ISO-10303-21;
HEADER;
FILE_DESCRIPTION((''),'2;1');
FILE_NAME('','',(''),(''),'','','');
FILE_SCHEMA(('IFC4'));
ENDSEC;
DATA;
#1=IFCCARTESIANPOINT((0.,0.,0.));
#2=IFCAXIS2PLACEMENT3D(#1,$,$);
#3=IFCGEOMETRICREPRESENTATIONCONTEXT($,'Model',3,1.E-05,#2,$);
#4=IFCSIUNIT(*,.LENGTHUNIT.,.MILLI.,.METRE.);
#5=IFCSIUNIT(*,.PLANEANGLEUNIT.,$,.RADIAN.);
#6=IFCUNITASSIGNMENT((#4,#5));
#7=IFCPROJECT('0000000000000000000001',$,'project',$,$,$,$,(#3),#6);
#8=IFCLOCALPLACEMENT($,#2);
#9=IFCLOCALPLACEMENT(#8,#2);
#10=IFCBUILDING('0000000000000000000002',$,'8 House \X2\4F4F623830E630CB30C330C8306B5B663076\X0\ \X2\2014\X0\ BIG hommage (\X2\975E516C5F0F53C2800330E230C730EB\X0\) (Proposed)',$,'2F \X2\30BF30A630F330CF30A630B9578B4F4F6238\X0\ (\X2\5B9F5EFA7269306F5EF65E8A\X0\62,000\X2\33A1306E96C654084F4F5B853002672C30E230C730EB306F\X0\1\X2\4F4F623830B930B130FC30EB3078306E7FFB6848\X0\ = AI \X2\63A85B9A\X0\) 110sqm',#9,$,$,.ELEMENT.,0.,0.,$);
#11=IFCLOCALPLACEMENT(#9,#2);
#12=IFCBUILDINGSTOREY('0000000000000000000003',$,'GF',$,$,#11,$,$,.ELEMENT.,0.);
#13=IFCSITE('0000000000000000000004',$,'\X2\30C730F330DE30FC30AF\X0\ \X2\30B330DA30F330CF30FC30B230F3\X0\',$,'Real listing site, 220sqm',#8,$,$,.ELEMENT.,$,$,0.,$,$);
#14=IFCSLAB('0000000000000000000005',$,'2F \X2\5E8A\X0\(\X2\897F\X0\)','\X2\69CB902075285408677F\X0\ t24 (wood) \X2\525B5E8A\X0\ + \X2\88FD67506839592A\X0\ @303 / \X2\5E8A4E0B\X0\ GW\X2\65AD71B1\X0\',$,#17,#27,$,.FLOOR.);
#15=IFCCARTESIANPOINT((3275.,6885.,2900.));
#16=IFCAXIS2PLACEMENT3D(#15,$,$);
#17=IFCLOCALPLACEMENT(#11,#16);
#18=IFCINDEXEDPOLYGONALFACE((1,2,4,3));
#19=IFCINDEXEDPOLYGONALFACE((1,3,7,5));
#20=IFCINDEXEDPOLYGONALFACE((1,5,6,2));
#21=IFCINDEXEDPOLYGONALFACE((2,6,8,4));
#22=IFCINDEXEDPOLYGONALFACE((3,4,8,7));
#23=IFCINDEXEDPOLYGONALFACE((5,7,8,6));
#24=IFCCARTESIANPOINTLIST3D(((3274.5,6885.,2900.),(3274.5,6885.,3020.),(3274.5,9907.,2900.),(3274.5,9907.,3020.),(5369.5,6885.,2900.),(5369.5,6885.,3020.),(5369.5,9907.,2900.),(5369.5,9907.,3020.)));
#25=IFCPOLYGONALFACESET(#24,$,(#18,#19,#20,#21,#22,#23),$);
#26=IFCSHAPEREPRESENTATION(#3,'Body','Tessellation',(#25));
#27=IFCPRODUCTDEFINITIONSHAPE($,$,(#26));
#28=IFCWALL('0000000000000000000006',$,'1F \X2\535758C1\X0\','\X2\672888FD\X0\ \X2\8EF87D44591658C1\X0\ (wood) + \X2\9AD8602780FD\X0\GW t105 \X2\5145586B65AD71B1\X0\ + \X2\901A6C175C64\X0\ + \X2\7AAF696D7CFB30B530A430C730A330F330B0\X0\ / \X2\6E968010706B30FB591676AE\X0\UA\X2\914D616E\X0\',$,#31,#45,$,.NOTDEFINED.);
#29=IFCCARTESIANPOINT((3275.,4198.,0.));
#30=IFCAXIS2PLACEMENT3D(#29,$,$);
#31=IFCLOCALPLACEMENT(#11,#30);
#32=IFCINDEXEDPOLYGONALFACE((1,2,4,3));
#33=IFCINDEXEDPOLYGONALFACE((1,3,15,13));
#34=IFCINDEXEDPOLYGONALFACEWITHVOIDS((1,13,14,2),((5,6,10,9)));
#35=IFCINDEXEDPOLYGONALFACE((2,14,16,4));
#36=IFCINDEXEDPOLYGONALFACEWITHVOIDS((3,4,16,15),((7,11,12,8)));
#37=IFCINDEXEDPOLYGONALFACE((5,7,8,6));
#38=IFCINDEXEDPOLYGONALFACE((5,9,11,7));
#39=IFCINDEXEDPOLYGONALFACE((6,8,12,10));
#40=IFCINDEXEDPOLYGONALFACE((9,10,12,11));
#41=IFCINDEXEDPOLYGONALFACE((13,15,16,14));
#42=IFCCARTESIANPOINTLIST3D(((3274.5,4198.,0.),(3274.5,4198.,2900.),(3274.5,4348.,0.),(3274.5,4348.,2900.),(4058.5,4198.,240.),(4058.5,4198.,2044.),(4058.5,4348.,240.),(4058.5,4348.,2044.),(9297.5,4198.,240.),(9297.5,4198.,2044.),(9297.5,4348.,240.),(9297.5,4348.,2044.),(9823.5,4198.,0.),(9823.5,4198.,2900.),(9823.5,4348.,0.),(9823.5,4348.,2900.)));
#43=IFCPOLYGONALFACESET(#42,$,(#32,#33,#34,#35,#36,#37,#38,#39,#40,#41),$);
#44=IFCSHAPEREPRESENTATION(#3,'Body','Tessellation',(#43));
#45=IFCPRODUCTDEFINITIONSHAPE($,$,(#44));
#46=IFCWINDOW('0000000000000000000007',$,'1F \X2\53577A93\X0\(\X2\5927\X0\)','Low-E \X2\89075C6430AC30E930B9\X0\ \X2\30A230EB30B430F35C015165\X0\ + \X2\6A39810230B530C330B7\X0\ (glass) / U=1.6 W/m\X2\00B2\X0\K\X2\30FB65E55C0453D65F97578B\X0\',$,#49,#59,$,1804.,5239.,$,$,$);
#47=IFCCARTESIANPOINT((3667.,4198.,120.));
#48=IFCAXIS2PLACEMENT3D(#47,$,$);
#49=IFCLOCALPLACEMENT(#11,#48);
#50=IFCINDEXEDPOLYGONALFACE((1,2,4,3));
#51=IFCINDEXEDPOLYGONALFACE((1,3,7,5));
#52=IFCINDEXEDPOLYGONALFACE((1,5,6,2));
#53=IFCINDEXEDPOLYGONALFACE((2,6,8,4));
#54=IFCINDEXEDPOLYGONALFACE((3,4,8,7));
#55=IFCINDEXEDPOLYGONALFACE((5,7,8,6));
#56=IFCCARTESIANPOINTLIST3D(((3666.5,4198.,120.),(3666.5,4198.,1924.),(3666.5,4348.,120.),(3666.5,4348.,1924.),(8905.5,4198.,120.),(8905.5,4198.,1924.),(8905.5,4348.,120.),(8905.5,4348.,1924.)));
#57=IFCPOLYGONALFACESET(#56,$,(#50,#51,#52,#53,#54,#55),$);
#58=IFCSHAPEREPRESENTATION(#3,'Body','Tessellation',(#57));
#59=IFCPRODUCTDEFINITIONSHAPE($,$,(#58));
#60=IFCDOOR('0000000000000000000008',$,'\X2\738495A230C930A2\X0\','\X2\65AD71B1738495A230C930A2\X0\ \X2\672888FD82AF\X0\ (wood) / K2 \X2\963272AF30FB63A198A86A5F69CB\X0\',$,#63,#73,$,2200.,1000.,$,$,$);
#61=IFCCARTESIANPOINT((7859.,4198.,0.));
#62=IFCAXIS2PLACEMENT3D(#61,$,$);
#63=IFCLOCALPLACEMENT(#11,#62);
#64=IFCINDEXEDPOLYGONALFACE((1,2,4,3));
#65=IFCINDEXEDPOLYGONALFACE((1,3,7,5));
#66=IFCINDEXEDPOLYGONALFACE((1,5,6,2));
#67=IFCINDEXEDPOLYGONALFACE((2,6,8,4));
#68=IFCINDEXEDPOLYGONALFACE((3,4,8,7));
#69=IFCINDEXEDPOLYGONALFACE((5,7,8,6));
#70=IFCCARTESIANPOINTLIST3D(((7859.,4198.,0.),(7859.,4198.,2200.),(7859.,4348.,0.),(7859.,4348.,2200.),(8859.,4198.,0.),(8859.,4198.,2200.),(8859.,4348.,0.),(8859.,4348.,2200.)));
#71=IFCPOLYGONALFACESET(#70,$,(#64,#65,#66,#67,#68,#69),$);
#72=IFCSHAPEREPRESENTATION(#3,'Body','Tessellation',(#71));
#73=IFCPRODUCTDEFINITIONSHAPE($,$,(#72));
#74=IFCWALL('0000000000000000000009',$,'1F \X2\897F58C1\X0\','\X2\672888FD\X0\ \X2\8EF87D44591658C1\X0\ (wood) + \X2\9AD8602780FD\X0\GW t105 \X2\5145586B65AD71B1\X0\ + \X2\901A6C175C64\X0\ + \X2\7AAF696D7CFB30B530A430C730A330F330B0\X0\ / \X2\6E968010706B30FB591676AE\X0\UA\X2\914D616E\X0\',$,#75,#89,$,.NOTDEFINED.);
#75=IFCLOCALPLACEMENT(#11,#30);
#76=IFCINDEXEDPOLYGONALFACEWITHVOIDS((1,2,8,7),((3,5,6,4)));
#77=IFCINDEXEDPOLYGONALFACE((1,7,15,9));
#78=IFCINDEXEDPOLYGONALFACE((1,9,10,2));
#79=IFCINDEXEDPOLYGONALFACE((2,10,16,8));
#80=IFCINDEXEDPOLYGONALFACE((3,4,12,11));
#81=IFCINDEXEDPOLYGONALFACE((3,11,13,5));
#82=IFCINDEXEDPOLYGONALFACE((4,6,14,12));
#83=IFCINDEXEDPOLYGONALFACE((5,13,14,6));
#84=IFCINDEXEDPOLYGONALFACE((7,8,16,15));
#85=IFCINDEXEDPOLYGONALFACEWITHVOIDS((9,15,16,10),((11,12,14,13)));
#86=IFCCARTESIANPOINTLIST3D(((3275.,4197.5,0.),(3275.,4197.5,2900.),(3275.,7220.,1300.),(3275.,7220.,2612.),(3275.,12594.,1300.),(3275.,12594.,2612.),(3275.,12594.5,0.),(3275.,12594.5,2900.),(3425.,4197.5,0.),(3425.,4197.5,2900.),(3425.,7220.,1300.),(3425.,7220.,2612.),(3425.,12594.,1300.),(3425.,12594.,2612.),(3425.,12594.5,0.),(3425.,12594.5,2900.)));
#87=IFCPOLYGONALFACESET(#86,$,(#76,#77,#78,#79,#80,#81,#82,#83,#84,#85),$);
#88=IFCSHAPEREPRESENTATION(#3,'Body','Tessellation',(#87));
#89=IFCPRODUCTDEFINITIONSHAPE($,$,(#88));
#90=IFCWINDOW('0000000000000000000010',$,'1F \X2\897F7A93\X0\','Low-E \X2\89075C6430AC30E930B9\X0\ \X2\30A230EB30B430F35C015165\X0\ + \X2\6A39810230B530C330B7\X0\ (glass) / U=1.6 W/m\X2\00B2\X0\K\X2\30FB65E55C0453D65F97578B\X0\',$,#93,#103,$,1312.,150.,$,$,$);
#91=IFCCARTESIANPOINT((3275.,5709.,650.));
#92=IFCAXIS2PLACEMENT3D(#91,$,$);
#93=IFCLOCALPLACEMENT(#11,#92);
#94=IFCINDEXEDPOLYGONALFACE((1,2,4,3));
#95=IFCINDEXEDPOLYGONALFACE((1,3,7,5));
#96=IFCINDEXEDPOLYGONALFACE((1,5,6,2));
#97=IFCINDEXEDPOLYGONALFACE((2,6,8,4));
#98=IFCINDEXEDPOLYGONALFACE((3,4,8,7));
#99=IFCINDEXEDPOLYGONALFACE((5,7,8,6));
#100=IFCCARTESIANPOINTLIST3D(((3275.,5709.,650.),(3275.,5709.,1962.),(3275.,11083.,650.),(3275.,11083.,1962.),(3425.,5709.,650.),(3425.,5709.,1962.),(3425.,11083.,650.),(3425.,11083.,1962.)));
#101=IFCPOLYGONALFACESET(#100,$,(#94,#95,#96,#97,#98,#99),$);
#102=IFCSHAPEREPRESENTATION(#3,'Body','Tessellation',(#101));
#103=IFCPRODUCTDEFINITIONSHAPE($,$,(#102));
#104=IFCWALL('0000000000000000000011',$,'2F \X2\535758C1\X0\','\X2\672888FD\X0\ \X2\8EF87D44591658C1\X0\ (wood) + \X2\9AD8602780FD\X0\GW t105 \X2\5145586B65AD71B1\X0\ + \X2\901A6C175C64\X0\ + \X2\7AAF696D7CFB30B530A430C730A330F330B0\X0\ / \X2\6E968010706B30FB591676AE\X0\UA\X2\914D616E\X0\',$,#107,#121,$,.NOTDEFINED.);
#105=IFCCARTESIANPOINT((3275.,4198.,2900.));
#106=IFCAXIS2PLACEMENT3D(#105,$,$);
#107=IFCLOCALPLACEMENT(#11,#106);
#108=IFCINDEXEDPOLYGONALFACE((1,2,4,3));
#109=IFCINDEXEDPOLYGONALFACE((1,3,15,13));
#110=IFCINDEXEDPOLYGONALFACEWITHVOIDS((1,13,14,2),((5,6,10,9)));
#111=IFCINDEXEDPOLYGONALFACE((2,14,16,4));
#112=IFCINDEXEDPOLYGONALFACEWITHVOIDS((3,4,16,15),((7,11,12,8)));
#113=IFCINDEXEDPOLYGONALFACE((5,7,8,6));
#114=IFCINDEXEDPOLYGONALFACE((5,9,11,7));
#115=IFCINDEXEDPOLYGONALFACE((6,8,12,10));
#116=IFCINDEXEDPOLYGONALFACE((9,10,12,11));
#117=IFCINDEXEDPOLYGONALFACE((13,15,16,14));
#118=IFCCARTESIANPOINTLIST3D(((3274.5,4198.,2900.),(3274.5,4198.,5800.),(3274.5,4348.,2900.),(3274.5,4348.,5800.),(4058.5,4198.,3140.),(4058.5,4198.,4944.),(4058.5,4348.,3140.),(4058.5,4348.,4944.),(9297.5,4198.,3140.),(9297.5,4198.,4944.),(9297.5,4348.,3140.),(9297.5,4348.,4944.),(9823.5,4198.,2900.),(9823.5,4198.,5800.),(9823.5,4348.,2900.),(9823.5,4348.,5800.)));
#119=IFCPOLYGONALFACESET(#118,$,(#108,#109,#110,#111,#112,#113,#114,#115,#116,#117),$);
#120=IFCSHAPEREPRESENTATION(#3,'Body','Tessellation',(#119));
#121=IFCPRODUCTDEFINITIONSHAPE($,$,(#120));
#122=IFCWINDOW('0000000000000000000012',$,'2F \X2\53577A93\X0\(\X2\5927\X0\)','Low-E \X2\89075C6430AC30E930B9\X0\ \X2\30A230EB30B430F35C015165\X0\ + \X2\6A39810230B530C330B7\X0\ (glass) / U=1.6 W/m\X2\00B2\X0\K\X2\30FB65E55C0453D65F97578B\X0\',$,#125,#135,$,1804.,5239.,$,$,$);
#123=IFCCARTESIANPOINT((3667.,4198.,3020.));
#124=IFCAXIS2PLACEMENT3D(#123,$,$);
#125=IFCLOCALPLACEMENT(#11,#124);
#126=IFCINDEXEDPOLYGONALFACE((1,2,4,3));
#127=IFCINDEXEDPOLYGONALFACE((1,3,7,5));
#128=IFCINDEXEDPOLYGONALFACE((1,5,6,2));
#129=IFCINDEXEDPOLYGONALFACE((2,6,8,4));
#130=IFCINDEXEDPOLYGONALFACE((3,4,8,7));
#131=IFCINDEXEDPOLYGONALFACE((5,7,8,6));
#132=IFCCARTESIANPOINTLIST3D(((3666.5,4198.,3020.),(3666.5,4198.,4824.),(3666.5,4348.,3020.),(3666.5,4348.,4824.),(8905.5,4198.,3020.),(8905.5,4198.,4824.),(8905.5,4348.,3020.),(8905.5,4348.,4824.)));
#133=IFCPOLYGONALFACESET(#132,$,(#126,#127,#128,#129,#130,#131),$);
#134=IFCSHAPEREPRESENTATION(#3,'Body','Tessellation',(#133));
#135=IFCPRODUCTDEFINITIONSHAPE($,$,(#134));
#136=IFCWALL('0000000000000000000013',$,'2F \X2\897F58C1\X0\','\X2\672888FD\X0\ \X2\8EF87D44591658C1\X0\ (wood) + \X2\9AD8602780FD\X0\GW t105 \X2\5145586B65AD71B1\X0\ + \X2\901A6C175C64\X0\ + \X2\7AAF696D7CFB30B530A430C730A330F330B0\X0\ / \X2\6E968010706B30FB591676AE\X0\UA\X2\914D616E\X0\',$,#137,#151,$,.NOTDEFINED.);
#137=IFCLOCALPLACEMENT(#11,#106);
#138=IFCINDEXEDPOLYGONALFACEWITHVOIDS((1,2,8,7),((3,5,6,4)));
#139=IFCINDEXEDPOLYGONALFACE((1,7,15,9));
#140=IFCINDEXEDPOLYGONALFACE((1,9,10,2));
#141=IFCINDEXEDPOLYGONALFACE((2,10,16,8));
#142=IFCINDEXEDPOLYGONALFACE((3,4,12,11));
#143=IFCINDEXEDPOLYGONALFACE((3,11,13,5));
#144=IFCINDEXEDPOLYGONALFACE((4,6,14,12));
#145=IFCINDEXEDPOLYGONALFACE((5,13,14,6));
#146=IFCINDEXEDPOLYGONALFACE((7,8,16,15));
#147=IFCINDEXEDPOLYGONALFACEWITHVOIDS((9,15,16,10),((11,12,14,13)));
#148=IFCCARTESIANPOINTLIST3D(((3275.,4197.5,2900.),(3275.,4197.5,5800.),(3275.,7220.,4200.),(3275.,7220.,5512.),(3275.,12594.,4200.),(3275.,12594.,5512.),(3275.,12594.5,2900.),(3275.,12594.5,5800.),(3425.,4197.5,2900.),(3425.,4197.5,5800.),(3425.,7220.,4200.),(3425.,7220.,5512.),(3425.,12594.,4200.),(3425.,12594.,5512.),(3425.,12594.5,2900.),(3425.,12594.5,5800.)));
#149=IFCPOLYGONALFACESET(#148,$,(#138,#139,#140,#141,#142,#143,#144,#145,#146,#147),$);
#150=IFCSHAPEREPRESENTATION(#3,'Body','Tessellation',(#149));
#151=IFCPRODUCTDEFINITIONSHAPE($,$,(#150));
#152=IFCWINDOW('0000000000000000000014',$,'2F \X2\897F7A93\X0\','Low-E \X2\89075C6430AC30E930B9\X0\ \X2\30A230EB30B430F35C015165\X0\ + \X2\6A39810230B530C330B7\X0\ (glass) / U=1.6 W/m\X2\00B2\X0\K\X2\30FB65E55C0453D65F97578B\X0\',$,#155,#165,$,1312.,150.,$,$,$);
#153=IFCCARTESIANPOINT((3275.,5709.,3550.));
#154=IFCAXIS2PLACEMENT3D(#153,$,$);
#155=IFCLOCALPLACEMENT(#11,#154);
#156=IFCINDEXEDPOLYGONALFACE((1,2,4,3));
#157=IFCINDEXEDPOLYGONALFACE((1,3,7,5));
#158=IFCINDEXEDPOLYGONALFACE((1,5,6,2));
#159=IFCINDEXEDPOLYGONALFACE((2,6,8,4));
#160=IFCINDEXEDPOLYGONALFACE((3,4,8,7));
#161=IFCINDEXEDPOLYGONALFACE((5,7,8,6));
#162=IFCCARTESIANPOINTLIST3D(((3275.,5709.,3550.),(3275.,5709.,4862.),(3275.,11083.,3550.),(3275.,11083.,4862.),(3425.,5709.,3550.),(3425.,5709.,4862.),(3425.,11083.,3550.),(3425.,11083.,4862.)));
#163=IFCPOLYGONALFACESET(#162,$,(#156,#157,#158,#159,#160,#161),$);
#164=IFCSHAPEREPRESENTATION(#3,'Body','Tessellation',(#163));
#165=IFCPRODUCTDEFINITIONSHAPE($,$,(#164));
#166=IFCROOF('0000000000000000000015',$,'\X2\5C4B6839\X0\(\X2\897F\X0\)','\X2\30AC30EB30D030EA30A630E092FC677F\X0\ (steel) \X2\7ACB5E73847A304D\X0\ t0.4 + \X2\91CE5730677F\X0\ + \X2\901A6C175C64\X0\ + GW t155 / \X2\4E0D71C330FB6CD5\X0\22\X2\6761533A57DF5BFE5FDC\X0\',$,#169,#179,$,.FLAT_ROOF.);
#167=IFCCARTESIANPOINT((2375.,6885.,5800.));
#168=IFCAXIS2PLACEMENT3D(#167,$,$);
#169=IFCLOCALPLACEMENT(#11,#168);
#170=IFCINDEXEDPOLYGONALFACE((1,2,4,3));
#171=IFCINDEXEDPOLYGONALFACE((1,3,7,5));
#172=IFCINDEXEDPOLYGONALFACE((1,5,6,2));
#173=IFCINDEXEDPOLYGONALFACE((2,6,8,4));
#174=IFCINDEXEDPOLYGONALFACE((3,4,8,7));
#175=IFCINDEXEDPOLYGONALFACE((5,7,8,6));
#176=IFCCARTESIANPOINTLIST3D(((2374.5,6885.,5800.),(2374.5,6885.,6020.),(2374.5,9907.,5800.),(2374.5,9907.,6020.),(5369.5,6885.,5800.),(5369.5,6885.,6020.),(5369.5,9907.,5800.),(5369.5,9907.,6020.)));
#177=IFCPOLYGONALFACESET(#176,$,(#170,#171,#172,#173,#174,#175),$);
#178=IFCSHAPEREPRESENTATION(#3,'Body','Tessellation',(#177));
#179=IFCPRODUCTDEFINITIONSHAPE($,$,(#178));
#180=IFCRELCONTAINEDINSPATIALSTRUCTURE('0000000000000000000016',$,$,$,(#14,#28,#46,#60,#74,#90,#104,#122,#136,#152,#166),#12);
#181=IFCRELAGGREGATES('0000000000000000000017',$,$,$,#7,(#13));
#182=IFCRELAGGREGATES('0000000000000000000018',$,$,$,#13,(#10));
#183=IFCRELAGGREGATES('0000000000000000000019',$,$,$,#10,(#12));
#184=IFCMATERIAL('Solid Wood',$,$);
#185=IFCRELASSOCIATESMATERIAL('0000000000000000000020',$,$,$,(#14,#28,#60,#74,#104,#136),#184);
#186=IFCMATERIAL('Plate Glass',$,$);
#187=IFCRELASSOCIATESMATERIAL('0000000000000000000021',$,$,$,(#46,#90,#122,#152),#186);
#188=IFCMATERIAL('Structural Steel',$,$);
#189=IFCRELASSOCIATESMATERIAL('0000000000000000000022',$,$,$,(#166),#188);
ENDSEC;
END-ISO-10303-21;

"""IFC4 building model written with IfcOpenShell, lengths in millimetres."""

from ifc_helpers import new_model, si_unit, frame, frame_2d, origin, place, context, project, spatial, rectangle, extrude, material, element, fill, save


model = new_model("IFC4")

# Units and contexts
model_context = context("Model", 3, precision=1e-05, world=origin())
ifc_project = project(units=[si_unit("LENGTHUNIT", "METRE", prefix="MILLI"), si_unit("PLANEANGLEUNIT", "RADIAN")], contexts=[model_context])

# Site, building, storey
site_placement = place(None, origin())
site = spatial("IfcSite", under=ifc_project, at=site_placement, Name="デンマーク コペンハーゲン", ObjectType="Real listing site, 220sqm", CompositionType="ELEMENT", RefElevation=0.0)
building_placement = place(site_placement, origin())
building = spatial("IfcBuilding", under=site, at=building_placement, Name="8 House 住戸ユニットに学ぶ — BIG hommage (非公式参考モデル) (Proposed)", ObjectType="2F タウンハウス型住戸 (実建物は延床62,000㎡の集合住宅。本モデルは1住戸スケールへの翻案 = AI 推定) 110sqm", CompositionType="ELEMENT", ElevationOfRefHeight=0.0, ElevationOfTerrain=0.0)
storey_placement = place(building_placement, origin())
storey = spatial("IfcBuildingStorey", under=building, at=storey_placement, Name="GF", CompositionType="ELEMENT", Elevation=0.0)

# Slab
ifc_material_1 = material(Name="Solid Wood")
slab_1_placement = place(storey_placement, frame((3275.0, 6885.0, 2900.0)))
element("IfcSlab", 1, at=slab_1_placement, inside=storey, material=ifc_material_1, Name="2F 床(西)", Description="構造用合板 t24 (wood) 剛床 + 製材根太 @303 / 床下 GW断熱", PredefinedType="FLOOR", context=model_context, shape_type="SweptSolid", body=[
    extrude(rectangle(XDim=2095.0, YDim=3022.0, at=frame_2d((1047.0, 1511.0))), frame((3275.0, 6885.0, 2900.0)), (0.0, 0.0, 1.0), 120.0),
])

# Wall, openings, window, door
wall_1_placement = place(storey_placement, frame((3275.0, 4198.0, 0.0)))
wall_1 = element("IfcWall", 2, at=wall_1_placement, inside=storey, material=ifc_material_1, Name="1F 南壁", Description="木製 軸組外壁 (wood) + 高性能GW t105 充填断熱 + 通気層 + 窯業系サイディング / 準耐火・外皮UA配慮", PredefinedType="NOTDEFINED", context=model_context, shape_type="SweptSolid", body=[
    extrude(rectangle(XDim=6549.0, YDim=150.0, at=frame_2d((3274.0, 75.0))), frame((3275.0, 4198.0, 0.0)), (0.0, 0.0, 1.0), 2900.0),
])
opening_1_placement = place(storey_placement, frame((3667.0, 4198.0, 120.0)))
opening_1 = element("IfcOpeningElement", 3, at=opening_1_placement, cuts=wall_1, PredefinedType="NOTDEFINED", context=model_context, shape_type="SweptSolid", body=[
    extrude(rectangle(XDim=5239.0, YDim=150.0, at=frame_2d((2619.0, 75.0))), frame((3667.0, 4198.0, 120.0)), (0.0, 0.0, 1.0), 1804.0),
])
opening_2_placement = place(storey_placement, frame((7859.0, 4198.0, 0.0)))
opening_2 = element("IfcOpeningElement", 4, at=opening_2_placement, cuts=wall_1, PredefinedType="NOTDEFINED", context=model_context, shape_type="SweptSolid", body=[
    extrude(rectangle(XDim=1000.0, YDim=150.0, at=frame_2d((500.0, 75.0))), frame((7859.0, 4198.0, 0.0)), (0.0, 0.0, 1.0), 2200.0),
])
ifc_material_2 = material(Name="Plate Glass")
window_1_placement = place(storey_placement, frame((3667.0, 4198.0, 120.0)))
window_1 = element("IfcWindow", 5, at=window_1_placement, inside=storey, material=ifc_material_2, Name="1F 南窓(大)", Description="Low-E 複層ガラス アルゴン封入 + 樹脂サッシ (glass) / U=1.6 W/m²K・日射取得型", OverallHeight=1804.0, OverallWidth=5239.0, context=model_context, shape_type="SweptSolid", body=[
    extrude(rectangle(XDim=5239.0, YDim=150.0, at=frame_2d((2619.0, 75.0))), frame((3667.0, 4198.0, 120.0)), (0.0, 0.0, 1.0), 1804.0),
])
fill(opening_1, window_1)
door_placement = place(storey_placement, frame((7859.0, 4198.0, 0.0)))
door = element("IfcDoor", 6, at=door_placement, inside=storey, material=ifc_material_1, Name="玄関ドア", Description="断熱玄関ドア 木製芯 (wood) / K2 防犯・採風機構", OverallHeight=2200.0, OverallWidth=1000.0, context=model_context, shape_type="SweptSolid", body=[
    extrude(rectangle(XDim=1000.0, YDim=150.0, at=frame_2d((500.0, 75.0))), frame((7859.0, 4198.0, 0.0)), (0.0, 0.0, 1.0), 2200.0),
])
fill(opening_2, door)

# Walls, openings, windows
wall_2_placement = place(storey_placement, frame((3275.0, 4198.0, 0.0)))
wall_2 = element("IfcWall", 7, at=wall_2_placement, inside=storey, material=ifc_material_1, Name="1F 西壁", Description="木製 軸組外壁 (wood) + 高性能GW t105 充填断熱 + 通気層 + 窯業系サイディング / 準耐火・外皮UA配慮", PredefinedType="NOTDEFINED", context=model_context, shape_type="SweptSolid", body=[
    extrude(rectangle(XDim=150.0, YDim=8397.0, at=frame_2d((75.0, 4198.0))), frame((3275.0, 4198.0, 0.0)), (0.0, 0.0, 1.0), 2900.0),
])
opening_3_placement = place(storey_placement, frame((3275.0, 5709.0, 650.0)))
opening_3 = element("IfcOpeningElement", 8, at=opening_3_placement, cuts=wall_2, PredefinedType="NOTDEFINED", context=model_context, shape_type="SweptSolid", body=[
    extrude(rectangle(XDim=150.0, YDim=5374.0, at=frame_2d((75.0, 2687.0))), frame((3275.0, 5709.0, 650.0)), (0.0, 0.0, 1.0), 1312.0),
])
window_2_placement = place(storey_placement, frame((3275.0, 5709.0, 650.0)))
window_2 = element("IfcWindow", 9, at=window_2_placement, inside=storey, material=ifc_material_2, Name="1F 西窓", Description="Low-E 複層ガラス アルゴン封入 + 樹脂サッシ (glass) / U=1.6 W/m²K・日射取得型", OverallHeight=1312.0, OverallWidth=150.0, context=model_context, shape_type="SweptSolid", body=[
    extrude(rectangle(XDim=150.0, YDim=5374.0, at=frame_2d((75.0, 2687.0))), frame((3275.0, 5709.0, 650.0)), (0.0, 0.0, 1.0), 1312.0),
])
fill(opening_3, window_2)
wall_3_placement = place(storey_placement, frame((3275.0, 4198.0, 2900.0)))
wall_3 = element("IfcWall", 10, at=wall_3_placement, inside=storey, material=ifc_material_1, Name="2F 南壁", Description="木製 軸組外壁 (wood) + 高性能GW t105 充填断熱 + 通気層 + 窯業系サイディング / 準耐火・外皮UA配慮", PredefinedType="NOTDEFINED", context=model_context, shape_type="SweptSolid", body=[
    extrude(rectangle(XDim=6549.0, YDim=150.0, at=frame_2d((3274.0, 75.0))), frame((3275.0, 4198.0, 2900.0)), (0.0, 0.0, 1.0), 2900.0),
])
opening_4_placement = place(storey_placement, frame((3667.0, 4198.0, 3020.0)))
opening_4 = element("IfcOpeningElement", 11, at=opening_4_placement, cuts=wall_3, PredefinedType="NOTDEFINED", context=model_context, shape_type="SweptSolid", body=[
    extrude(rectangle(XDim=5239.0, YDim=150.0, at=frame_2d((2619.0, 75.0))), frame((3667.0, 4198.0, 3020.0)), (0.0, 0.0, 1.0), 1804.0),
])
window_3_placement = place(storey_placement, frame((3667.0, 4198.0, 3020.0)))
window_3 = element("IfcWindow", 12, at=window_3_placement, inside=storey, material=ifc_material_2, Name="2F 南窓(大)", Description="Low-E 複層ガラス アルゴン封入 + 樹脂サッシ (glass) / U=1.6 W/m²K・日射取得型", OverallHeight=1804.0, OverallWidth=5239.0, context=model_context, shape_type="SweptSolid", body=[
    extrude(rectangle(XDim=5239.0, YDim=150.0, at=frame_2d((2619.0, 75.0))), frame((3667.0, 4198.0, 3020.0)), (0.0, 0.0, 1.0), 1804.0),
])
fill(opening_4, window_3)
wall_4_placement = place(storey_placement, frame((3275.0, 4198.0, 2900.0)))
wall_4 = element("IfcWall", 13, at=wall_4_placement, inside=storey, material=ifc_material_1, Name="2F 西壁", Description="木製 軸組外壁 (wood) + 高性能GW t105 充填断熱 + 通気層 + 窯業系サイディング / 準耐火・外皮UA配慮", PredefinedType="NOTDEFINED", context=model_context, shape_type="SweptSolid", body=[
    extrude(rectangle(XDim=150.0, YDim=8397.0, at=frame_2d((75.0, 4198.0))), frame((3275.0, 4198.0, 2900.0)), (0.0, 0.0, 1.0), 2900.0),
])
opening_5_placement = place(storey_placement, frame((3275.0, 5709.0, 3550.0)))
opening_5 = element("IfcOpeningElement", 14, at=opening_5_placement, cuts=wall_4, PredefinedType="NOTDEFINED", context=model_context, shape_type="SweptSolid", body=[
    extrude(rectangle(XDim=150.0, YDim=5374.0, at=frame_2d((75.0, 2687.0))), frame((3275.0, 5709.0, 3550.0)), (0.0, 0.0, 1.0), 1312.0),
])
window_4_placement = place(storey_placement, frame((3275.0, 5709.0, 3550.0)))
window_4 = element("IfcWindow", 15, at=window_4_placement, inside=storey, material=ifc_material_2, Name="2F 西窓", Description="Low-E 複層ガラス アルゴン封入 + 樹脂サッシ (glass) / U=1.6 W/m²K・日射取得型", OverallHeight=1312.0, OverallWidth=150.0, context=model_context, shape_type="SweptSolid", body=[
    extrude(rectangle(XDim=150.0, YDim=5374.0, at=frame_2d((75.0, 2687.0))), frame((3275.0, 5709.0, 3550.0)), (0.0, 0.0, 1.0), 1312.0),
])
fill(opening_5, window_4)

# Roof
ifc_material_3 = material(Name="Structural Steel")
roof_1_placement = place(storey_placement, frame((2375.0, 6885.0, 5800.0)))
element("IfcRoof", 16, at=roof_1_placement, inside=storey, material=ifc_material_3, Name="屋根(西)", Description="ガルバリウム鋼板 (steel) 立平葺き t0.4 + 野地板 + 通気層 + GW t155 / 不燃・法22条区域対応", PredefinedType="FLAT_ROOF", context=model_context, shape_type="SweptSolid", body=[
    extrude(rectangle(XDim=2995.0, YDim=3022.0, at=frame_2d((1497.0, 1511.0))), frame((2375.0, 6885.0, 5800.0)), (0.0, 0.0, 1.0), 220.0),
])

save(model, "model.ifc")
